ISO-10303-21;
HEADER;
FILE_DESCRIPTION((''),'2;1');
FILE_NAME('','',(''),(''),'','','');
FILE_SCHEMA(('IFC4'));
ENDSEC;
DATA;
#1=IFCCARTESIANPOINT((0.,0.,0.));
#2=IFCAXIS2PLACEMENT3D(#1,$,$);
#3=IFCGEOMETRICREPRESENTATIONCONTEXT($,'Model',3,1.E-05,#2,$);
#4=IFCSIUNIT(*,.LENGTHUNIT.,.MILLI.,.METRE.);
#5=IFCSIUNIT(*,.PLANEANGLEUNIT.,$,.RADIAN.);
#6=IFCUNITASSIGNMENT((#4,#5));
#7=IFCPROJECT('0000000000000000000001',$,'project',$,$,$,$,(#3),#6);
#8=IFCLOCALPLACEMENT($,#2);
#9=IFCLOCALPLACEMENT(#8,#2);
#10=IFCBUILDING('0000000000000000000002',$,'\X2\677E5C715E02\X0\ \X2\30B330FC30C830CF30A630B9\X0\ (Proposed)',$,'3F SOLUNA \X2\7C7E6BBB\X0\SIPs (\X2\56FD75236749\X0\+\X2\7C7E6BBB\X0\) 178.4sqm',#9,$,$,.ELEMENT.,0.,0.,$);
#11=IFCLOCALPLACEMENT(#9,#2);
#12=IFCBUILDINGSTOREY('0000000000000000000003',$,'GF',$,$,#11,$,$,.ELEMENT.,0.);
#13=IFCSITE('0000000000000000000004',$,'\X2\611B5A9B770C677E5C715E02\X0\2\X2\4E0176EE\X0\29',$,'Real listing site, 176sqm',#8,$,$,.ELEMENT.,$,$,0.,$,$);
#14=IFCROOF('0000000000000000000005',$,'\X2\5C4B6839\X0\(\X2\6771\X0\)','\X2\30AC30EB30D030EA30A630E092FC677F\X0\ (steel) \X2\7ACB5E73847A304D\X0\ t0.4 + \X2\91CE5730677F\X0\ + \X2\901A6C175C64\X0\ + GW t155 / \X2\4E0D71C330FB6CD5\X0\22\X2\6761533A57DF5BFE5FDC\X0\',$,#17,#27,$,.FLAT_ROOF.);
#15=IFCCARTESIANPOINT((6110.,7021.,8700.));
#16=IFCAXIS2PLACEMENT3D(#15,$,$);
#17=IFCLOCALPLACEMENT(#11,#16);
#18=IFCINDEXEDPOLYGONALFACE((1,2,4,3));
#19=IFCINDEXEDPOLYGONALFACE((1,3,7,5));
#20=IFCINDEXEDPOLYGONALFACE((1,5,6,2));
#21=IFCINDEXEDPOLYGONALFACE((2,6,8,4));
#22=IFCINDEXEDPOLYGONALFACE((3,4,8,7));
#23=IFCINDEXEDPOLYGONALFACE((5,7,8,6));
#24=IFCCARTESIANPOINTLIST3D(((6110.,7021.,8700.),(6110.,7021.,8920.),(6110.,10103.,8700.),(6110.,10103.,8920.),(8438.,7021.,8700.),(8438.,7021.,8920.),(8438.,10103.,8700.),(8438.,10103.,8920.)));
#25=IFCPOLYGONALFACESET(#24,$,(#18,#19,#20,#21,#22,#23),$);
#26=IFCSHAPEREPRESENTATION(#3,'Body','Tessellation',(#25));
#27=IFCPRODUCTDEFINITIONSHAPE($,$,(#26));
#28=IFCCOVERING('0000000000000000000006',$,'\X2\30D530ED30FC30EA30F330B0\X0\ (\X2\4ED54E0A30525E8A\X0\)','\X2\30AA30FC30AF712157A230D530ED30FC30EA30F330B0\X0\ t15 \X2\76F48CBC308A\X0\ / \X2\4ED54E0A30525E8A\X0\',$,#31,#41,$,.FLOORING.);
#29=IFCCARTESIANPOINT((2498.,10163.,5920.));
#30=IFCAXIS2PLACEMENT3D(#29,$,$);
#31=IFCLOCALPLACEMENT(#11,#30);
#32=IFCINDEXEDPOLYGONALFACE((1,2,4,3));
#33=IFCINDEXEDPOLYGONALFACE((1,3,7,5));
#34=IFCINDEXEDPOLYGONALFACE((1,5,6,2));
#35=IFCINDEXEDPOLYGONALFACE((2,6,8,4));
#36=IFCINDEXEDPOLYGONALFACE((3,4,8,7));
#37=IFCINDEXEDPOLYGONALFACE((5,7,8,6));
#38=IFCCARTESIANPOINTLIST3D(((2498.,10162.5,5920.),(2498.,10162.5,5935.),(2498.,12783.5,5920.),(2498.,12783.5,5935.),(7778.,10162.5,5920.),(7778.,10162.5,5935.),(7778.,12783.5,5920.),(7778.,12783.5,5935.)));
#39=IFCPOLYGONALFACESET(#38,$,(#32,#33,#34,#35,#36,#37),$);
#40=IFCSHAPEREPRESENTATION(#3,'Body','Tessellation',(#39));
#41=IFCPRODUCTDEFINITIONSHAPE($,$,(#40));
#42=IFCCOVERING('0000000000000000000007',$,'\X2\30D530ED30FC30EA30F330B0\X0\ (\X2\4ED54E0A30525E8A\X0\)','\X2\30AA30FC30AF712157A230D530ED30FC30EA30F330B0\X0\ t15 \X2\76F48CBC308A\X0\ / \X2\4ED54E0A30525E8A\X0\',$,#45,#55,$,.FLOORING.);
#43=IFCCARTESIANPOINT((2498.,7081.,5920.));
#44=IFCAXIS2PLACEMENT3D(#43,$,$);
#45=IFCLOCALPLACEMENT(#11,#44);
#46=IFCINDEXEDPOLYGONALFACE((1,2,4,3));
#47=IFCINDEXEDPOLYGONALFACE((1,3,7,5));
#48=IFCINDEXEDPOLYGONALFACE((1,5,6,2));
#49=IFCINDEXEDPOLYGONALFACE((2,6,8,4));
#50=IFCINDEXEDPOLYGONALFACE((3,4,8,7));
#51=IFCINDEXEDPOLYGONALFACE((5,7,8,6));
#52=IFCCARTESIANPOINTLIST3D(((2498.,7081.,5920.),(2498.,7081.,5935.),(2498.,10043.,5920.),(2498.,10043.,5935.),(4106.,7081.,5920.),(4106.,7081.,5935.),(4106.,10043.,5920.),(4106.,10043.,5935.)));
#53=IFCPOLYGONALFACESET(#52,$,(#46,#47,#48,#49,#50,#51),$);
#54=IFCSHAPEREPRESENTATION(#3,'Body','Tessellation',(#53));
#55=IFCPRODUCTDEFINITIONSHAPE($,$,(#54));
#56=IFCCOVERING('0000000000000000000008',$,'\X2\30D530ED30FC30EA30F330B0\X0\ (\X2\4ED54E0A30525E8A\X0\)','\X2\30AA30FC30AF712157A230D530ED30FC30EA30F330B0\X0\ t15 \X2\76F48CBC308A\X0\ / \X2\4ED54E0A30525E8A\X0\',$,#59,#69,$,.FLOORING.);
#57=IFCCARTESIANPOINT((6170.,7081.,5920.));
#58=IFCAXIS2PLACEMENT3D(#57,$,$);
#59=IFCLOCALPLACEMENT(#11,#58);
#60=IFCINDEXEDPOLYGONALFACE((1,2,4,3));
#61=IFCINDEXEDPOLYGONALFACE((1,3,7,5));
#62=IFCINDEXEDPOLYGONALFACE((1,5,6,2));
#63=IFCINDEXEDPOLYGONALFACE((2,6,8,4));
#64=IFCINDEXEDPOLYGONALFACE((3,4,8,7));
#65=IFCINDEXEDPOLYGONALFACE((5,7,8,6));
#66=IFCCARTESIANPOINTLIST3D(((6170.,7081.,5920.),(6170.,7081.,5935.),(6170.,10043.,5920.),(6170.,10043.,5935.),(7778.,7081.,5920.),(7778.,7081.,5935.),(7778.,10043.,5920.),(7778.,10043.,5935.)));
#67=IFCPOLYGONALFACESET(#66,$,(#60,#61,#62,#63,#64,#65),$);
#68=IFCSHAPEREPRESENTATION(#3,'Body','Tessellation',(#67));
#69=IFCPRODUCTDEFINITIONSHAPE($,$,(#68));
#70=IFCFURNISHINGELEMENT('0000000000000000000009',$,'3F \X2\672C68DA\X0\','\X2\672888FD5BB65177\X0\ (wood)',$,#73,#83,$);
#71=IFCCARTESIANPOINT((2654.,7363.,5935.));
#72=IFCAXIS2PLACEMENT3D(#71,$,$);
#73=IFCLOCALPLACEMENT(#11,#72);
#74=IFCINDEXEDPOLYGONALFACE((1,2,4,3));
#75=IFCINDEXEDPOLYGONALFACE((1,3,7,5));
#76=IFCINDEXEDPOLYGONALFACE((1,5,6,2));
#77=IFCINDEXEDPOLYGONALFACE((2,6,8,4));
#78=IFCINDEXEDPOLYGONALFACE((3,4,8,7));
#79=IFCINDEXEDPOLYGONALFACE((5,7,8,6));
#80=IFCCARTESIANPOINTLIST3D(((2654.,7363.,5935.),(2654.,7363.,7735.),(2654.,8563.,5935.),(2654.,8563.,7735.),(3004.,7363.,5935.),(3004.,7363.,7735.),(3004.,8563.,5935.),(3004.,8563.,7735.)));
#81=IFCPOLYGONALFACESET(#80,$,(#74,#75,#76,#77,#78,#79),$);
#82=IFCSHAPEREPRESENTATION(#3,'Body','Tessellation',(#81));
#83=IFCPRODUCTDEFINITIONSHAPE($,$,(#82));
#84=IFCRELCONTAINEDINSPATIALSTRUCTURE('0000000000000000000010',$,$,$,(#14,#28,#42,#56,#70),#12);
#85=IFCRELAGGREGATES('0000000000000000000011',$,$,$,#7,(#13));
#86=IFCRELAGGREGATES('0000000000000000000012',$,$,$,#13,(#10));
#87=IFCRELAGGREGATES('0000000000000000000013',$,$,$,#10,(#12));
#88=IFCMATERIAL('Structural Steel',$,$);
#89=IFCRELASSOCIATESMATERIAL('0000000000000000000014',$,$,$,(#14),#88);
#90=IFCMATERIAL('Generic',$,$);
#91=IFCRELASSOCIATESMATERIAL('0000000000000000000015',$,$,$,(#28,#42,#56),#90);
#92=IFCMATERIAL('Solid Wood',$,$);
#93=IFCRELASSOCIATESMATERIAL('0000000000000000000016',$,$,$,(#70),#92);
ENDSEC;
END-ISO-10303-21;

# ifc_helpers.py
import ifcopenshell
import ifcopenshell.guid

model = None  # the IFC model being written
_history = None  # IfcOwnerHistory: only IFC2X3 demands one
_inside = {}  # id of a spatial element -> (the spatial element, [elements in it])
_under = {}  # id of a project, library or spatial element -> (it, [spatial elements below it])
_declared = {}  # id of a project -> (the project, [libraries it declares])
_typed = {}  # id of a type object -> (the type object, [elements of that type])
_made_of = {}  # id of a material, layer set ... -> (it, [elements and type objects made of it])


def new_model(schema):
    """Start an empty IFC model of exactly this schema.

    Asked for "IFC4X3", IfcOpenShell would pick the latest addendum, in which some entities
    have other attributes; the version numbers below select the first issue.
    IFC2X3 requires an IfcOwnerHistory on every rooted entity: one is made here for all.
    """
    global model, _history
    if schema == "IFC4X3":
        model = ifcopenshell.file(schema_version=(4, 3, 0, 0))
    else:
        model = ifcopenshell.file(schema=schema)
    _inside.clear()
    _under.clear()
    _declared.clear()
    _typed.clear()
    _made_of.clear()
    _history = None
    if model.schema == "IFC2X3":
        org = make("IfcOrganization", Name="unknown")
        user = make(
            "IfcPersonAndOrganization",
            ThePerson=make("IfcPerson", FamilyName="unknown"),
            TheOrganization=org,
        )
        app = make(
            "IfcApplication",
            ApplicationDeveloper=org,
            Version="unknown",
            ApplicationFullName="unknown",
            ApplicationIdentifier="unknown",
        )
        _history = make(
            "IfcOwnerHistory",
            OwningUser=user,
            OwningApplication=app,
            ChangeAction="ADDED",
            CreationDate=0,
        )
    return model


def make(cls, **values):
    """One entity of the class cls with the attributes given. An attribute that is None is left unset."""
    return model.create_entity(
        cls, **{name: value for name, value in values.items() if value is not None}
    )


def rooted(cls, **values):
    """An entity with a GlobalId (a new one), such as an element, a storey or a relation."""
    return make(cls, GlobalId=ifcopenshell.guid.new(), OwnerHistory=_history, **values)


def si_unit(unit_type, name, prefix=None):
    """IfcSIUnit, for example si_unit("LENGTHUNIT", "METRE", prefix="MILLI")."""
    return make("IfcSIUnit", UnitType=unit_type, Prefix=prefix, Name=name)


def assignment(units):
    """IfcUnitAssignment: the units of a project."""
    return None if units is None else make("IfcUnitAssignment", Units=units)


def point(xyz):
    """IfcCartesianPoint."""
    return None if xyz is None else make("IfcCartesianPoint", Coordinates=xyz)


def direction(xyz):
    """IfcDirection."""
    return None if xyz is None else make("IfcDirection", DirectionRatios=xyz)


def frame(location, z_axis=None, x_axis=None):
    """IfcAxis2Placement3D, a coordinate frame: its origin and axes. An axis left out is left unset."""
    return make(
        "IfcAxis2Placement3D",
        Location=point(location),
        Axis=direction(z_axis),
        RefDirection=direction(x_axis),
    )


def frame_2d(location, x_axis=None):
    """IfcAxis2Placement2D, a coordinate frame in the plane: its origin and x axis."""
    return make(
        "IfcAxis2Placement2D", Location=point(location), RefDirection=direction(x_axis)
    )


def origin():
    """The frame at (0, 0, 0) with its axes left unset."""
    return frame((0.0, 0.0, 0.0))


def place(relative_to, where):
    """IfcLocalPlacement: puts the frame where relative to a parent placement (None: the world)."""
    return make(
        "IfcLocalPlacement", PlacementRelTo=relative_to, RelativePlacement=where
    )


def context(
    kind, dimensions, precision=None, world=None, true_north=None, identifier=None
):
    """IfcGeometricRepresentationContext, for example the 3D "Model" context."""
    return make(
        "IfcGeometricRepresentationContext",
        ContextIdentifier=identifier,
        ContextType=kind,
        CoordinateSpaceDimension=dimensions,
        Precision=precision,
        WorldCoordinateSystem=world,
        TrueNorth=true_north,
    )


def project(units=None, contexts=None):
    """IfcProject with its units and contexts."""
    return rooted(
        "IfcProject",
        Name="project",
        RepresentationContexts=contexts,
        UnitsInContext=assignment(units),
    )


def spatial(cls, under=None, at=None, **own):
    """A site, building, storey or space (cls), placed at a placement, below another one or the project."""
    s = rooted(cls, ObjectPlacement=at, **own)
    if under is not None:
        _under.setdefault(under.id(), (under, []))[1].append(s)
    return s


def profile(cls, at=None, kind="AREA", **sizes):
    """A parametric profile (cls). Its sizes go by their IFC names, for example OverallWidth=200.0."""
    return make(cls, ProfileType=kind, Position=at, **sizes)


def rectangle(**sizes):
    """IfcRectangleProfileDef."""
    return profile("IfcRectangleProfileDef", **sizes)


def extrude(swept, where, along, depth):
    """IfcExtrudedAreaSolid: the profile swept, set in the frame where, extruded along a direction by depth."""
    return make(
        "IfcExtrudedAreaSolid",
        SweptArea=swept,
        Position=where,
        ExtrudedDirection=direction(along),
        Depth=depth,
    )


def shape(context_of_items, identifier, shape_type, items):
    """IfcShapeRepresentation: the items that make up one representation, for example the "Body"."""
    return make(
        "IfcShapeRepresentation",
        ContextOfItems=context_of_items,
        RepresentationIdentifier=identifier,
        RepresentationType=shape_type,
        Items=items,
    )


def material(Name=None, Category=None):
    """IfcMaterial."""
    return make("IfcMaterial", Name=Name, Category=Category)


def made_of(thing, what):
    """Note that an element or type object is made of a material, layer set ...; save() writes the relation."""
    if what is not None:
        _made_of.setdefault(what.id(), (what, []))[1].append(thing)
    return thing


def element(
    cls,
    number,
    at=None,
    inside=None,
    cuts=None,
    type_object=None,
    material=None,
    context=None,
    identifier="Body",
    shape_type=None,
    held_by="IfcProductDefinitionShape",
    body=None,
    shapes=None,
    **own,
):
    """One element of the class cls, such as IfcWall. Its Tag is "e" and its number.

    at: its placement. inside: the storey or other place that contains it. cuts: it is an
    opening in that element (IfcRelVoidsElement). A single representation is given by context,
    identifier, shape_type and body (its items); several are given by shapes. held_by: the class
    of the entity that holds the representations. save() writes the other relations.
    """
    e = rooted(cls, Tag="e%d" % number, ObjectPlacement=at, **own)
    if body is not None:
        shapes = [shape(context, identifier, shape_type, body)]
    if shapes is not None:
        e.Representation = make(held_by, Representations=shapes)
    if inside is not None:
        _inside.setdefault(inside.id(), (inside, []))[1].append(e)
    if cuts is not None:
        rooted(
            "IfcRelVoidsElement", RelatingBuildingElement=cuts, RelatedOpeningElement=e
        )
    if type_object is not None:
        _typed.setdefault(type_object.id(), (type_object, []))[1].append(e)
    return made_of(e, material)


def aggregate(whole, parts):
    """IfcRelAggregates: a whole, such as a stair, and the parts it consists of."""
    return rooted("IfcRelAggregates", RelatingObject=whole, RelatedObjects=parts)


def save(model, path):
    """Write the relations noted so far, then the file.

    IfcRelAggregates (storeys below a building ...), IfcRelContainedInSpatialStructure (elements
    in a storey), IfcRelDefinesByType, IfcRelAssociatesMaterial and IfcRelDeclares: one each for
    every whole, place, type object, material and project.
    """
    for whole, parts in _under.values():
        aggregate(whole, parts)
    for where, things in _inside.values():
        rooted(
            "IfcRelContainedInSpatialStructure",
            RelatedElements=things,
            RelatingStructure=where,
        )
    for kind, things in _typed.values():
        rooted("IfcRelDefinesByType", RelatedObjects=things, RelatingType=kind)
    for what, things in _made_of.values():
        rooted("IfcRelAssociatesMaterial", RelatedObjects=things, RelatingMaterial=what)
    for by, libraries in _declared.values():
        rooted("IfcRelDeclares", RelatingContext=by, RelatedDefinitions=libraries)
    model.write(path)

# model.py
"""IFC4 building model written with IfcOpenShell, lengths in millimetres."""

from ifc_helpers import new_model, si_unit, frame, frame_2d, origin, place, context, project, spatial, rectangle, extrude, material, element, save


model = new_model("IFC4")

# Units and contexts
model_context = context("Model", 3, precision=1e-05, world=origin())
ifc_project = project(units=[si_unit("LENGTHUNIT", "METRE", prefix="MILLI"), si_unit("PLANEANGLEUNIT", "RADIAN")], contexts=[model_context])

# Site, building, storey
site_placement = place(None, origin())
site = spatial("IfcSite", under=ifc_project, at=site_placement, Name="愛媛県松山市2丁目29", ObjectType="Real listing site, 176sqm", CompositionType="ELEMENT", RefElevation=0.0)
building_placement = place(site_placement, origin())
building = spatial("IfcBuilding", under=site, at=building_placement, Name="松山市 コートハウス (Proposed)", ObjectType="3F SOLUNA 籾殻SIPs (国産杉+籾殻) 178.4sqm", CompositionType="ELEMENT", ElevationOfRefHeight=0.0, ElevationOfTerrain=0.0)
storey_placement = place(building_placement, origin())
storey = spatial("IfcBuildingStorey", under=building, at=storey_placement, Name="GF", CompositionType="ELEMENT", Elevation=0.0)

# Shared definitions
ifc_material_1 = material(Name="Solid Wood")

# Shared definitions
ifc_material_2 = material(Name="Generic")

# Roof
ifc_material_3 = material(Name="Structural Steel")
roof_1_placement = place(storey_placement, frame((6110.0, 7021.0, 8700.0)))
element("IfcRoof", 1, at=roof_1_placement, inside=storey, material=ifc_material_3, Name="屋根(東)", Description="ガルバリウム鋼板 (steel) 立平葺き t0.4 + 野地板 + 通気層 + GW t155 / 不燃・法22条区域対応", PredefinedType="FLAT_ROOF", context=model_context, shape_type="SweptSolid", body=[
    extrude(rectangle(XDim=2328.0, YDim=3082.0, at=frame_2d((1164.0, 1541.0))), frame((6110.0, 7021.0, 8700.0)), (0.0, 0.0, 1.0), 220.0),
])

# Coverings
covering_1_placement = place(storey_placement, frame((2498.0, 10163.0, 5920.0)))
element("IfcCovering", 2, at=covering_1_placement, inside=storey, material=ifc_material_2, Name="フローリング (仕上げ床)", Description="オーク無垢フローリング t15 直貼り / 仕上げ床", PredefinedType="FLOORING", context=model_context, shape_type="SweptSolid", body=[
    extrude(rectangle(XDim=5280.0, YDim=2621.0, at=frame_2d((2640.0, 1310.0))), frame((2498.0, 10163.0, 5920.0)), (0.0, 0.0, 1.0), 15.0),
])
covering_2_placement = place(storey_placement, frame((2498.0, 7081.0, 5920.0)))
element("IfcCovering", 3, at=covering_2_placement, inside=storey, material=ifc_material_2, Name="フローリング (仕上げ床)", Description="オーク無垢フローリング t15 直貼り / 仕上げ床", PredefinedType="FLOORING", context=model_context, shape_type="SweptSolid", body=[
    extrude(rectangle(XDim=1608.0, YDim=2962.0, at=frame_2d((804.0, 1481.0))), frame((2498.0, 7081.0, 5920.0)), (0.0, 0.0, 1.0), 15.0),
])
covering_3_placement = place(storey_placement, frame((6170.0, 7081.0, 5920.0)))
element("IfcCovering", 4, at=covering_3_placement, inside=storey, material=ifc_material_2, Name="フローリング (仕上げ床)", Description="オーク無垢フローリング t15 直貼り / 仕上げ床", PredefinedType="FLOORING", context=model_context, shape_type="SweptSolid", body=[
    extrude(rectangle(XDim=1608.0, YDim=2962.0, at=frame_2d((804.0, 1481.0))), frame((6170.0, 7081.0, 5920.0)), (0.0, 0.0, 1.0), 15.0),
])

# Furnishing element
furnishing_placement = place(storey_placement, frame((2654.0, 7363.0, 5935.0)))
element("IfcFurnishingElement", 5, at=furnishing_placement, inside=storey, material=ifc_material_1, Name="3F 本棚", Description="木製家具 (wood)", context=model_context, shape_type="SweptSolid", body=[
    extrude(rectangle(XDim=350.0, YDim=1200.0, at=frame_2d((175.0, 600.0))), frame((2654.0, 7363.0, 5935.0)), (0.0, 0.0, 1.0), 1800.0),
])

save(model, "model.ifc")
